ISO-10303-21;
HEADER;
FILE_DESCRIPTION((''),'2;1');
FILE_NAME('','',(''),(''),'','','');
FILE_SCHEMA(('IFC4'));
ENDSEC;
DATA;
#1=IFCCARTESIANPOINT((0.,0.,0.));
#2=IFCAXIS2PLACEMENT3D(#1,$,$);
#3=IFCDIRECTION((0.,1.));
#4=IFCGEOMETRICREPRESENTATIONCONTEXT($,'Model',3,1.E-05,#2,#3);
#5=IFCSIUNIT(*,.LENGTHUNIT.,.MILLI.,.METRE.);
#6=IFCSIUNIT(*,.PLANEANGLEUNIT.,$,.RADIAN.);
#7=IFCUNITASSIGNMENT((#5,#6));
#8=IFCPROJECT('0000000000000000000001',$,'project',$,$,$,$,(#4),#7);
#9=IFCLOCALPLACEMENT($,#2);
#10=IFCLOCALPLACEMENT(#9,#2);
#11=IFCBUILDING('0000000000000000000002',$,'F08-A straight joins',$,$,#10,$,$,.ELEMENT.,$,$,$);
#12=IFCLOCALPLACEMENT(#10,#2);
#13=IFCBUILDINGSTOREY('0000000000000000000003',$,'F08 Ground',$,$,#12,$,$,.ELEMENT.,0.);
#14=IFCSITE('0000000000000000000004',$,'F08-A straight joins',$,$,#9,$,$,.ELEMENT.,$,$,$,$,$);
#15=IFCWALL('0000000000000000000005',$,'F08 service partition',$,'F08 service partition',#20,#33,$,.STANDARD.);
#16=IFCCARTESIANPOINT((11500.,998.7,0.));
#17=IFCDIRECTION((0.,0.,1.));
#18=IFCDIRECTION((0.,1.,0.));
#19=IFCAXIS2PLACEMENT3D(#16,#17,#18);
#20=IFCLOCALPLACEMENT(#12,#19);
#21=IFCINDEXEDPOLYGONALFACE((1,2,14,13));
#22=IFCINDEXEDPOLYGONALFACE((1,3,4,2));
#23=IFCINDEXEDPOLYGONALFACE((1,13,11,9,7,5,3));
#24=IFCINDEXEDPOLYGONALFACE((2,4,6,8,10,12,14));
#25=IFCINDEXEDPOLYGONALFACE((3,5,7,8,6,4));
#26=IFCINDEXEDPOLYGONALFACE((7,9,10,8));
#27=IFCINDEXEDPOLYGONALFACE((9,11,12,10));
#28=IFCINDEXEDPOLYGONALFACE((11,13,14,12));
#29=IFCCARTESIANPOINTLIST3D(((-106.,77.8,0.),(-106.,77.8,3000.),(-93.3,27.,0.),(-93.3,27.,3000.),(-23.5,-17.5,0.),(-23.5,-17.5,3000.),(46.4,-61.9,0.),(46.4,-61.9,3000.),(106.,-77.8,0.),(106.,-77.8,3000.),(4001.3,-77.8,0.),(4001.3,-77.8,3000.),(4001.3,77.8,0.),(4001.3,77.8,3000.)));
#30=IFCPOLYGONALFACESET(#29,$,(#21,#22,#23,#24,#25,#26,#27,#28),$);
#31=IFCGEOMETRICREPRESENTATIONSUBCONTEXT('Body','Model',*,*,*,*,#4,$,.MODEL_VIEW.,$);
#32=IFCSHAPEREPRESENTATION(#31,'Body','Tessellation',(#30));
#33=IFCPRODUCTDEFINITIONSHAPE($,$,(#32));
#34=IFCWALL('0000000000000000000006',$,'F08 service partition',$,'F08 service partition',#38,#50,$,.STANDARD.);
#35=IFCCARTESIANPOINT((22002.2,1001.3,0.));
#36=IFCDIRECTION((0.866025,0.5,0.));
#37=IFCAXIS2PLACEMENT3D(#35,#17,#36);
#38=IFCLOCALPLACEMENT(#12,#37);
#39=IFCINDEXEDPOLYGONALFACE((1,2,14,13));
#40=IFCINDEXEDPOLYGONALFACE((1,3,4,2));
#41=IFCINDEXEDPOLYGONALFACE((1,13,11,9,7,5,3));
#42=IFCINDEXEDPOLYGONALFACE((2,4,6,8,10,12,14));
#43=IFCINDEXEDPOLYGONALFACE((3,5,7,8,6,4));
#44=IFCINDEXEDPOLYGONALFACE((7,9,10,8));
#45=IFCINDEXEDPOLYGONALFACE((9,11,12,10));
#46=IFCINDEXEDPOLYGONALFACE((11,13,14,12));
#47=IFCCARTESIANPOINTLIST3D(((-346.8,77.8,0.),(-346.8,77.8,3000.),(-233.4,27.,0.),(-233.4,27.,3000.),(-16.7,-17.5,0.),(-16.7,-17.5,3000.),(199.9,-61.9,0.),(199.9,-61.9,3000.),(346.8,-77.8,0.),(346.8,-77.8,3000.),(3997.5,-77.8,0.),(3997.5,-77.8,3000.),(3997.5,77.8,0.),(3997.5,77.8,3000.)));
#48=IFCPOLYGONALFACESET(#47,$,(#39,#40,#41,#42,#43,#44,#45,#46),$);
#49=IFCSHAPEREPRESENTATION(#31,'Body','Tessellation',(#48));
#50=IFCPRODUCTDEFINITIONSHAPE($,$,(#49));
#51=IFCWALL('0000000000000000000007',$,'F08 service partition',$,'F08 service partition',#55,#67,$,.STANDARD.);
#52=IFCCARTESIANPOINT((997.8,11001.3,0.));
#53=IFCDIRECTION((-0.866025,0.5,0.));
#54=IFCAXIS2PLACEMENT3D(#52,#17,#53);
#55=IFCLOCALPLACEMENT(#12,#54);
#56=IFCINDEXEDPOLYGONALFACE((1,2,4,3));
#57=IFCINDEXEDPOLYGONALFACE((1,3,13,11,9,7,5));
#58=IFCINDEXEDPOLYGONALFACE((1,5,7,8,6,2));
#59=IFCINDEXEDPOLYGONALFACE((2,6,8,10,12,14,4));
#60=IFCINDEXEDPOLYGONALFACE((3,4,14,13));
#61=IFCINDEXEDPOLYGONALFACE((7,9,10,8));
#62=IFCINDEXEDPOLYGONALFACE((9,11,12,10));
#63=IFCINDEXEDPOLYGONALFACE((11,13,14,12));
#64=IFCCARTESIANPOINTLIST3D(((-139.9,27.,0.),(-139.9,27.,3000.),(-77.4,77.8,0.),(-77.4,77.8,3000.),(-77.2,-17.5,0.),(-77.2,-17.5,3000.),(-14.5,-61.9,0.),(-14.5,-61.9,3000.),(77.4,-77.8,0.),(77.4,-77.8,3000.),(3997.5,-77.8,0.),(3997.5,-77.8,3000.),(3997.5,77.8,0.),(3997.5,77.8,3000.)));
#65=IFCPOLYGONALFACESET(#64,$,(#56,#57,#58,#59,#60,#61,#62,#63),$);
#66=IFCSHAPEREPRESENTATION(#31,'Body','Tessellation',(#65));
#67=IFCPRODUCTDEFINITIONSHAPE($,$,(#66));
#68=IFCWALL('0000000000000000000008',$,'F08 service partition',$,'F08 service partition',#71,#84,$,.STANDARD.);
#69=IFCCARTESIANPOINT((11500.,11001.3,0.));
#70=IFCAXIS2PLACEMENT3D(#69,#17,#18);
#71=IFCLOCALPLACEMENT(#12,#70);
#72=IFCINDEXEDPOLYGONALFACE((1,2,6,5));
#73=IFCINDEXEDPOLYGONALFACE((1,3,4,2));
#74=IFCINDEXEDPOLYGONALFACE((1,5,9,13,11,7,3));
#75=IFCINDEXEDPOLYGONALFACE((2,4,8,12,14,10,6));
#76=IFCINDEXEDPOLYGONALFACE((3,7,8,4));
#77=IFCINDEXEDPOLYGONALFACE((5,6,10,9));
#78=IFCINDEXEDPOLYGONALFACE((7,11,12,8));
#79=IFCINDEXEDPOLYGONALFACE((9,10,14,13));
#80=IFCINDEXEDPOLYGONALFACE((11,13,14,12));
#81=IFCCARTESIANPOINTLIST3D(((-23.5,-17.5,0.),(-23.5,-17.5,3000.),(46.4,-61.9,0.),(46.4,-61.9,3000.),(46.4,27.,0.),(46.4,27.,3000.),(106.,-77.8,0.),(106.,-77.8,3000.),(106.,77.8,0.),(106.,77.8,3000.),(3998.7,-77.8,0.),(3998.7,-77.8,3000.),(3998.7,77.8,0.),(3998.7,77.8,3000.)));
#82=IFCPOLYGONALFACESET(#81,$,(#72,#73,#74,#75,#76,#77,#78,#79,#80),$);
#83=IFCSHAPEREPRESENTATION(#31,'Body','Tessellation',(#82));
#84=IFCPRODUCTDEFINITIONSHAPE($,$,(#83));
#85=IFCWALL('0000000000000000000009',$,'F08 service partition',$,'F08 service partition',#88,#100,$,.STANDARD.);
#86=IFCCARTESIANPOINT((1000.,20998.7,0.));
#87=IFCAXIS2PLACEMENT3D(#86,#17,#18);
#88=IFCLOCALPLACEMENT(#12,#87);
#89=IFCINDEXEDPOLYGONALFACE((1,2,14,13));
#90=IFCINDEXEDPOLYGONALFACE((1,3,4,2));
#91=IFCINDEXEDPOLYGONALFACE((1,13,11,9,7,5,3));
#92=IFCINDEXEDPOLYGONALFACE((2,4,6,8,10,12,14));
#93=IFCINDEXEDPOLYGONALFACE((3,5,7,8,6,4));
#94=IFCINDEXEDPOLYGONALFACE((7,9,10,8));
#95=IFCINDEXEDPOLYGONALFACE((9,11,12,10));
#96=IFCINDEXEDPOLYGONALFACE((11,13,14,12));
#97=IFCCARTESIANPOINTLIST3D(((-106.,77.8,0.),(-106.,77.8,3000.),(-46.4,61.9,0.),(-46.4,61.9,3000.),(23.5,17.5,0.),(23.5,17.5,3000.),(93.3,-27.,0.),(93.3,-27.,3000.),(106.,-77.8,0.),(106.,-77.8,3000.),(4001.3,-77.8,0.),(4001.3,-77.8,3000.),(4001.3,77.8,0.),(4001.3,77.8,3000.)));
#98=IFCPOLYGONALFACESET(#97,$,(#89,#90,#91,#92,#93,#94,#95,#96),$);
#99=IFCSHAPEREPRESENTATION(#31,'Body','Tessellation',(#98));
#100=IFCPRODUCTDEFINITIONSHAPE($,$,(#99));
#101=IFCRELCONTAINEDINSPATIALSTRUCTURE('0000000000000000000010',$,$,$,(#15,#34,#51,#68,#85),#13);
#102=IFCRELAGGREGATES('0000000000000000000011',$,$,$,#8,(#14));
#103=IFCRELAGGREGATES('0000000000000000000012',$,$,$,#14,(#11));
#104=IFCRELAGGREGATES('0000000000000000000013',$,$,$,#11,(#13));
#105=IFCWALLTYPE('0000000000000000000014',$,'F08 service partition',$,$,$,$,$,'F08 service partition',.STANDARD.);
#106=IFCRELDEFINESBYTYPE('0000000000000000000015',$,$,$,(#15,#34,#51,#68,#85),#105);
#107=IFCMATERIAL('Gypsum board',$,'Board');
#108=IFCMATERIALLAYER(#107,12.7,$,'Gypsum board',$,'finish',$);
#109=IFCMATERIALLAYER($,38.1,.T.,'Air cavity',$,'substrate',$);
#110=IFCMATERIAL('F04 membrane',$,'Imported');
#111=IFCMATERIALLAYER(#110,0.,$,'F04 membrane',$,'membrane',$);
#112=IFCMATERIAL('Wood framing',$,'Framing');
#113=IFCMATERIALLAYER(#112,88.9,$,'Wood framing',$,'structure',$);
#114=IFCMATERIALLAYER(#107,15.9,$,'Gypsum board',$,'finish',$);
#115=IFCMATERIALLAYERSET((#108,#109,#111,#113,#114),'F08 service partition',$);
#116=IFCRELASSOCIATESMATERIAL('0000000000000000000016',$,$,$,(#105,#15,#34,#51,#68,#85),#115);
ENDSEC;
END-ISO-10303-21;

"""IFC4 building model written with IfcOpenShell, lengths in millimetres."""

from ifc_helpers import new_model, si_unit, direction, frame, origin, place, context, subcontext, project, spatial, polyline, outline, extrude, material, layer, layer_set, layer_usage, type_object, element, save


model = new_model("IFC4")

# Units and contexts
model_context = context("Model", 3, precision=1e-05, world=origin(), true_north=direction((0.0, 1.0)))
body_context = subcontext(model_context, "Body", "Model", "MODEL_VIEW")
ifc_project = project(units=[si_unit("LENGTHUNIT", "METRE", prefix="MILLI"), si_unit("PLANEANGLEUNIT", "RADIAN")], contexts=[model_context])

# Site, building, storey
site_placement = place(None, origin())
site = spatial("IfcSite", under=ifc_project, at=site_placement, Name="F08-A straight joins", CompositionType="ELEMENT")
building_placement = place(site_placement, origin())
building = spatial("IfcBuilding", under=site, at=building_placement, Name="F08-A straight joins", CompositionType="ELEMENT")
storey_placement = place(building_placement, origin())
storey = spatial("IfcBuildingStorey", under=building, at=storey_placement, Name="F08 Ground", CompositionType="ELEMENT", Elevation=0.0)

# Shared definitions
ifc_material_1 = material(Name="F04 membrane", Category="Imported")
ifc_material_2 = material(Name="Wood framing", Category="Framing")
ifc_material_3 = material(Name="Gypsum board", Category="Board")

# Walls
ifc_layer_1 = layer(ifc_material_3, 12.7, Name="Gypsum board", Category="finish")
ifc_layer_2 = layer(None, 38.1, ventilated=True, Name="Air cavity", Category="substrate")
ifc_layer_3 = layer(ifc_material_1, 0.0, Name="F04 membrane", Category="membrane")
ifc_layer_4 = layer(ifc_material_2, 88.9, Name="Wood framing", Category="structure")
ifc_layer_5 = layer(ifc_material_3, 15.9, Name="Gypsum board", Category="finish")
ifc_layer_set_1 = layer_set([ifc_layer_1, ifc_layer_2, ifc_layer_3, ifc_layer_4, ifc_layer_5], Name="F08 service partition")
ifc_layer_usage_1 = layer_usage(ifc_layer_set_1, "AXIS2", "NEGATIVE", 77.8)
wall_type_1 = type_object("IfcWallType", Name="F08 service partition", ElementType="F08 service partition", PredefinedType="STANDARD", material=ifc_layer_set_1)
wall_1_placement = place(storey_placement, frame((11500.0, 998.7, 0.0), z_axis=(0.0, 0.0, 1.0), x_axis=(0.0, 1.0, 0.0)))
element("IfcWall", 1, at=wall_1_placement, inside=storey, type_object=wall_type_1, material=ifc_layer_usage_1, Name="F08 service partition", ObjectType="F08 service partition", PredefinedType="STANDARD", context=body_context, shape_type="SweptSolid", body=[
    extrude(outline(polyline([(106.0, -77.8), (4001.3, -77.8), (4001.3, 77.8), (-106.0, 77.8), (-93.3, 27.0), (-23.5, -17.5), (46.4, -61.9), (106.0, -77.8)])), origin(), (0.0, 0.0, 1.0), 3000.0),
])
ifc_layer_usage_2 = layer_usage(ifc_layer_set_1, "AXIS2", "NEGATIVE", 77.8)
wall_2_placement = place(storey_placement, frame((22002.2, 1001.3, 0.0), z_axis=(0.0, 0.0, 1.0), x_axis=(0.866025, 0.5, 0.0)))
element("IfcWall", 2, at=wall_2_placement, inside=storey, type_object=wall_type_1, material=ifc_layer_usage_2, Name="F08 service partition", ObjectType="F08 service partition", PredefinedType="STANDARD", context=body_context, shape_type="SweptSolid", body=[
    extrude(outline(polyline([(346.8, -77.8), (3997.5, -77.8), (3997.5, 77.8), (-346.8, 77.8), (-233.4, 27.0), (-16.7, -17.5), (199.9, -61.9), (346.8, -77.8)])), origin(), (0.0, 0.0, 1.0), 3000.0),
])
ifc_layer_usage_3 = layer_usage(ifc_layer_set_1, "AXIS2", "NEGATIVE", 77.8)
wall_3_placement = place(storey_placement, frame((997.8, 11001.3, 0.0), z_axis=(0.0, 0.0, 1.0), x_axis=(-0.866025, 0.5, 0.0)))
element("IfcWall", 3, at=wall_3_placement, inside=storey, type_object=wall_type_1, material=ifc_layer_usage_3, Name="F08 service partition", ObjectType="F08 service partition", PredefinedType="STANDARD", context=body_context, shape_type="SweptSolid", body=[
    extrude(outline(polyline([(77.4, -77.8), (3997.5, -77.8), (3997.5, 77.8), (-77.4, 77.8), (-139.9, 27.0), (-77.2, -17.5), (-14.5, -61.9), (77.4, -77.8)])), origin(), (0.0, 0.0, 1.0), 3000.0),
])
ifc_layer_usage_4 = layer_usage(ifc_layer_set_1, "AXIS2", "NEGATIVE", 77.8)
wall_4_placement = place(storey_placement, frame((11500.0, 11001.3, 0.0), z_axis=(0.0, 0.0, 1.0), x_axis=(0.0, 1.0, 0.0)))
element("IfcWall", 4, at=wall_4_placement, inside=storey, type_object=wall_type_1, material=ifc_layer_usage_4, Name="F08 service partition", ObjectType="F08 service partition", PredefinedType="STANDARD", context=body_context, shape_type="SweptSolid", body=[
    extrude(outline(polyline([(106.0, -77.8), (3998.7, -77.8), (3998.7, 77.8), (106.0, 77.8), (46.4, 27.0), (-23.5, -17.5), (46.4, -61.9), (106.0, -77.8)])), origin(), (0.0, 0.0, 1.0), 3000.0),
])
ifc_layer_usage_5 = layer_usage(ifc_layer_set_1, "AXIS2", "POSITIVE", -77.8)
wall_5_placement = place(storey_placement, frame((1000.0, 20998.7, 0.0), z_axis=(0.0, 0.0, 1.0), x_axis=(0.0, 1.0, 0.0)))
element("IfcWall", 5, at=wall_5_placement, inside=storey, type_object=wall_type_1, material=ifc_layer_usage_5, Name="F08 service partition", ObjectType="F08 service partition", PredefinedType="STANDARD", context=body_context, shape_type="SweptSolid", body=[
    extrude(outline(polyline([(106.0, -77.8), (4001.3, -77.8), (4001.3, 77.8), (-106.0, 77.8), (-46.4, 61.9), (23.5, 17.5), (93.3, -27.0), (106.0, -77.8)])), origin(), (0.0, 0.0, 1.0), 3000.0),
])

save(model, "model.ifc")
